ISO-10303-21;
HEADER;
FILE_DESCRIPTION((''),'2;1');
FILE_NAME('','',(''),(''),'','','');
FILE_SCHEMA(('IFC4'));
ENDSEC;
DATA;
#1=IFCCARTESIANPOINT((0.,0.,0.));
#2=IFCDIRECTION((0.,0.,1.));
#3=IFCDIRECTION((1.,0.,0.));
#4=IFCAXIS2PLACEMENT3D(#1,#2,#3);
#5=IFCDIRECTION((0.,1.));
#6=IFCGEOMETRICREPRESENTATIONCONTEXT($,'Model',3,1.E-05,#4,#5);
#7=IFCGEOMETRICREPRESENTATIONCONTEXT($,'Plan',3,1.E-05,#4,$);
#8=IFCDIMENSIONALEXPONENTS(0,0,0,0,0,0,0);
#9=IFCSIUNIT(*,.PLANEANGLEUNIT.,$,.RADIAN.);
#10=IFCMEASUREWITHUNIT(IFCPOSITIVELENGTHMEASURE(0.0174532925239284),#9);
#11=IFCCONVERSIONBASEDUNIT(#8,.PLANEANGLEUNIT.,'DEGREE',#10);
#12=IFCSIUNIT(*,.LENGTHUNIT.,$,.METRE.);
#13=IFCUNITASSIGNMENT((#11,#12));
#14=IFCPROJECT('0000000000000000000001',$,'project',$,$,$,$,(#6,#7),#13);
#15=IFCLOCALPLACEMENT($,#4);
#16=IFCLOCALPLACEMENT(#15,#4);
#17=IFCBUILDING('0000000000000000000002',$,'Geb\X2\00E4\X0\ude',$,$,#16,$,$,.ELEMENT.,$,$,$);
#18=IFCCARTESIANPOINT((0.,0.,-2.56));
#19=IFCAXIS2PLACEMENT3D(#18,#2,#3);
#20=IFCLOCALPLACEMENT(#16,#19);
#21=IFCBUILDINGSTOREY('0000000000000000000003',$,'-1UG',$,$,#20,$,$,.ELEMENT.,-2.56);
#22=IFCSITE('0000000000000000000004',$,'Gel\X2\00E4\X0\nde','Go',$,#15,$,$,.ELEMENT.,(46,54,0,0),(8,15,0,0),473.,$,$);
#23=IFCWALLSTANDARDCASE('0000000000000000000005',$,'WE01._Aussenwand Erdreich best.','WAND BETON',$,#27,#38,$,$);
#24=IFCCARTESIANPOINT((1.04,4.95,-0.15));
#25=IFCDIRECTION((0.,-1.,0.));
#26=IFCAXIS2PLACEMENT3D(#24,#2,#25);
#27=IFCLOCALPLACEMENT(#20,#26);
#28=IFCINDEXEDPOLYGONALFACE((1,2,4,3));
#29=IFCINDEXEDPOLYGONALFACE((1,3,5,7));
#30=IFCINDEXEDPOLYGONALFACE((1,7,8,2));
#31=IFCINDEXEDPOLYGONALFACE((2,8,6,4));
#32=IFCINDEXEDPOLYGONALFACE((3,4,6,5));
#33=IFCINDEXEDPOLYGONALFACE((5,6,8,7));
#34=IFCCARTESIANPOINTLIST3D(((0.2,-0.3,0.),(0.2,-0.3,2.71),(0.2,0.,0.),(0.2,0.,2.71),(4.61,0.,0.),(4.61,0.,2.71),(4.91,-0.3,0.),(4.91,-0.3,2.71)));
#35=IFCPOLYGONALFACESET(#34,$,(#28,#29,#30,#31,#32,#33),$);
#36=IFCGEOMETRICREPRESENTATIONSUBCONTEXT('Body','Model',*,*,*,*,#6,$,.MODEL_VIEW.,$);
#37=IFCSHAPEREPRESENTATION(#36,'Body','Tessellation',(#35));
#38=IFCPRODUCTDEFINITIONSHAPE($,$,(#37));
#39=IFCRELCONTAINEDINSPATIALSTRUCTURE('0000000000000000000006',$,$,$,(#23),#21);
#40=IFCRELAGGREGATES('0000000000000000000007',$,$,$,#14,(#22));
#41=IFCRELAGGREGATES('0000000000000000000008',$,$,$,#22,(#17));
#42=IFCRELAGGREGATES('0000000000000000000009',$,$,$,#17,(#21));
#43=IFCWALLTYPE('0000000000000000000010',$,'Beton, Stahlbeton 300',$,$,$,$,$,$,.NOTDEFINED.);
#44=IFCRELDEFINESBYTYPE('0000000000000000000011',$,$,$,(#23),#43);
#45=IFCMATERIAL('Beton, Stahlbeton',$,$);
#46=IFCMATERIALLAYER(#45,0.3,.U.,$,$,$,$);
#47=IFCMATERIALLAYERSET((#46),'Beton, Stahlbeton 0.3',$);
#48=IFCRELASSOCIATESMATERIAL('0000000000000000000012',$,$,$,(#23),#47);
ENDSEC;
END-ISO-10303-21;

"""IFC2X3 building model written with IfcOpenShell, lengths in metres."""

from ifc_helpers import new_model, entity, si_unit, converted_unit, direction, frame, origin_with_axes, place, context, subcontext, project, spatial, polyline, outline, extrude, material, layer, layer_set, layer_usage, type_object, element, save


model = new_model("IFC2X3")

# Units and contexts
model_context = context("Model", 3, precision=1e-05, world=origin_with_axes(), true_north=direction((0.0, 1.0)))
plan_context = context("Plan", 3, precision=1e-05, world=origin_with_axes())
body_context = subcontext(model_context, "Body", "Model", "MODEL_VIEW")
ifc_project = project(units=[converted_unit("PLANEANGLEUNIT", "DEGREE", entity("IfcPositiveLengthMeasure", 0.0174532925239284), si_unit("PLANEANGLEUNIT", "RADIAN"), dimensions=[0, 0, 0, 0, 0, 0, 0]), si_unit("LENGTHUNIT", "METRE")], contexts=[model_context, plan_context])

# Site, building, storey
site_placement = place(None, origin_with_axes())
site = spatial("IfcSite", under=ifc_project, at=site_placement, Name="Gelände", Description="Go", CompositionType="ELEMENT", RefLatitude=(46, 54, 0, 0), RefLongitude=(8, 15, 0, 0), RefElevation=473.0)
building_placement = place(site_placement, origin_with_axes())
building = spatial("IfcBuilding", under=site, at=building_placement, Name="Gebäude", CompositionType="ELEMENT")
storey_placement = place(building_placement, frame((0.0, 0.0, -2.56), z_axis=(0.0, 0.0, 1.0), x_axis=(1.0, 0.0, 0.0)))
storey = spatial("IfcBuildingStorey", under=building, at=storey_placement, Name="-1UG", CompositionType="ELEMENT", Elevation=-2.56)

# Shared definitions
ifc_material_1 = material(Name="Beton, Stahlbeton")

# Wall
ifc_layer_1 = layer(ifc_material_1, 0.3, ventilated="UNKNOWN")
ifc_layer_set_1 = layer_set([ifc_layer_1], Name="Beton, Stahlbeton 0.3")
ifc_layer_usage_1 = layer_usage(ifc_layer_set_1, "AXIS2", "POSITIVE", -0.3)
wall_type_1 = type_object("IfcWallType", Name="Beton, Stahlbeton 300", PredefinedType="NOTDEFINED")
wall_1_placement = place(storey_placement, frame((1.04, 4.95, -0.15), z_axis=(0.0, 0.0, 1.0), x_axis=(0.0, -1.0, 0.0)))
element("IfcWallStandardCase", 1, at=wall_1_placement, inside=storey, type_object=wall_type_1, material=ifc_layer_usage_1, Name="WE01._Aussenwand Erdreich best.", Description="WAND BETON", context=body_context, shape_type="SweptSolid", body=[
    extrude(outline(polyline([(0.2, -0.3), (4.91, -0.3), (4.61, 0.0), (0.2, 0.0), (0.2, -0.3)])), origin_with_axes(), (0.0, 0.0, 1.0), 2.71),
])

save(model, "model.ifc")
